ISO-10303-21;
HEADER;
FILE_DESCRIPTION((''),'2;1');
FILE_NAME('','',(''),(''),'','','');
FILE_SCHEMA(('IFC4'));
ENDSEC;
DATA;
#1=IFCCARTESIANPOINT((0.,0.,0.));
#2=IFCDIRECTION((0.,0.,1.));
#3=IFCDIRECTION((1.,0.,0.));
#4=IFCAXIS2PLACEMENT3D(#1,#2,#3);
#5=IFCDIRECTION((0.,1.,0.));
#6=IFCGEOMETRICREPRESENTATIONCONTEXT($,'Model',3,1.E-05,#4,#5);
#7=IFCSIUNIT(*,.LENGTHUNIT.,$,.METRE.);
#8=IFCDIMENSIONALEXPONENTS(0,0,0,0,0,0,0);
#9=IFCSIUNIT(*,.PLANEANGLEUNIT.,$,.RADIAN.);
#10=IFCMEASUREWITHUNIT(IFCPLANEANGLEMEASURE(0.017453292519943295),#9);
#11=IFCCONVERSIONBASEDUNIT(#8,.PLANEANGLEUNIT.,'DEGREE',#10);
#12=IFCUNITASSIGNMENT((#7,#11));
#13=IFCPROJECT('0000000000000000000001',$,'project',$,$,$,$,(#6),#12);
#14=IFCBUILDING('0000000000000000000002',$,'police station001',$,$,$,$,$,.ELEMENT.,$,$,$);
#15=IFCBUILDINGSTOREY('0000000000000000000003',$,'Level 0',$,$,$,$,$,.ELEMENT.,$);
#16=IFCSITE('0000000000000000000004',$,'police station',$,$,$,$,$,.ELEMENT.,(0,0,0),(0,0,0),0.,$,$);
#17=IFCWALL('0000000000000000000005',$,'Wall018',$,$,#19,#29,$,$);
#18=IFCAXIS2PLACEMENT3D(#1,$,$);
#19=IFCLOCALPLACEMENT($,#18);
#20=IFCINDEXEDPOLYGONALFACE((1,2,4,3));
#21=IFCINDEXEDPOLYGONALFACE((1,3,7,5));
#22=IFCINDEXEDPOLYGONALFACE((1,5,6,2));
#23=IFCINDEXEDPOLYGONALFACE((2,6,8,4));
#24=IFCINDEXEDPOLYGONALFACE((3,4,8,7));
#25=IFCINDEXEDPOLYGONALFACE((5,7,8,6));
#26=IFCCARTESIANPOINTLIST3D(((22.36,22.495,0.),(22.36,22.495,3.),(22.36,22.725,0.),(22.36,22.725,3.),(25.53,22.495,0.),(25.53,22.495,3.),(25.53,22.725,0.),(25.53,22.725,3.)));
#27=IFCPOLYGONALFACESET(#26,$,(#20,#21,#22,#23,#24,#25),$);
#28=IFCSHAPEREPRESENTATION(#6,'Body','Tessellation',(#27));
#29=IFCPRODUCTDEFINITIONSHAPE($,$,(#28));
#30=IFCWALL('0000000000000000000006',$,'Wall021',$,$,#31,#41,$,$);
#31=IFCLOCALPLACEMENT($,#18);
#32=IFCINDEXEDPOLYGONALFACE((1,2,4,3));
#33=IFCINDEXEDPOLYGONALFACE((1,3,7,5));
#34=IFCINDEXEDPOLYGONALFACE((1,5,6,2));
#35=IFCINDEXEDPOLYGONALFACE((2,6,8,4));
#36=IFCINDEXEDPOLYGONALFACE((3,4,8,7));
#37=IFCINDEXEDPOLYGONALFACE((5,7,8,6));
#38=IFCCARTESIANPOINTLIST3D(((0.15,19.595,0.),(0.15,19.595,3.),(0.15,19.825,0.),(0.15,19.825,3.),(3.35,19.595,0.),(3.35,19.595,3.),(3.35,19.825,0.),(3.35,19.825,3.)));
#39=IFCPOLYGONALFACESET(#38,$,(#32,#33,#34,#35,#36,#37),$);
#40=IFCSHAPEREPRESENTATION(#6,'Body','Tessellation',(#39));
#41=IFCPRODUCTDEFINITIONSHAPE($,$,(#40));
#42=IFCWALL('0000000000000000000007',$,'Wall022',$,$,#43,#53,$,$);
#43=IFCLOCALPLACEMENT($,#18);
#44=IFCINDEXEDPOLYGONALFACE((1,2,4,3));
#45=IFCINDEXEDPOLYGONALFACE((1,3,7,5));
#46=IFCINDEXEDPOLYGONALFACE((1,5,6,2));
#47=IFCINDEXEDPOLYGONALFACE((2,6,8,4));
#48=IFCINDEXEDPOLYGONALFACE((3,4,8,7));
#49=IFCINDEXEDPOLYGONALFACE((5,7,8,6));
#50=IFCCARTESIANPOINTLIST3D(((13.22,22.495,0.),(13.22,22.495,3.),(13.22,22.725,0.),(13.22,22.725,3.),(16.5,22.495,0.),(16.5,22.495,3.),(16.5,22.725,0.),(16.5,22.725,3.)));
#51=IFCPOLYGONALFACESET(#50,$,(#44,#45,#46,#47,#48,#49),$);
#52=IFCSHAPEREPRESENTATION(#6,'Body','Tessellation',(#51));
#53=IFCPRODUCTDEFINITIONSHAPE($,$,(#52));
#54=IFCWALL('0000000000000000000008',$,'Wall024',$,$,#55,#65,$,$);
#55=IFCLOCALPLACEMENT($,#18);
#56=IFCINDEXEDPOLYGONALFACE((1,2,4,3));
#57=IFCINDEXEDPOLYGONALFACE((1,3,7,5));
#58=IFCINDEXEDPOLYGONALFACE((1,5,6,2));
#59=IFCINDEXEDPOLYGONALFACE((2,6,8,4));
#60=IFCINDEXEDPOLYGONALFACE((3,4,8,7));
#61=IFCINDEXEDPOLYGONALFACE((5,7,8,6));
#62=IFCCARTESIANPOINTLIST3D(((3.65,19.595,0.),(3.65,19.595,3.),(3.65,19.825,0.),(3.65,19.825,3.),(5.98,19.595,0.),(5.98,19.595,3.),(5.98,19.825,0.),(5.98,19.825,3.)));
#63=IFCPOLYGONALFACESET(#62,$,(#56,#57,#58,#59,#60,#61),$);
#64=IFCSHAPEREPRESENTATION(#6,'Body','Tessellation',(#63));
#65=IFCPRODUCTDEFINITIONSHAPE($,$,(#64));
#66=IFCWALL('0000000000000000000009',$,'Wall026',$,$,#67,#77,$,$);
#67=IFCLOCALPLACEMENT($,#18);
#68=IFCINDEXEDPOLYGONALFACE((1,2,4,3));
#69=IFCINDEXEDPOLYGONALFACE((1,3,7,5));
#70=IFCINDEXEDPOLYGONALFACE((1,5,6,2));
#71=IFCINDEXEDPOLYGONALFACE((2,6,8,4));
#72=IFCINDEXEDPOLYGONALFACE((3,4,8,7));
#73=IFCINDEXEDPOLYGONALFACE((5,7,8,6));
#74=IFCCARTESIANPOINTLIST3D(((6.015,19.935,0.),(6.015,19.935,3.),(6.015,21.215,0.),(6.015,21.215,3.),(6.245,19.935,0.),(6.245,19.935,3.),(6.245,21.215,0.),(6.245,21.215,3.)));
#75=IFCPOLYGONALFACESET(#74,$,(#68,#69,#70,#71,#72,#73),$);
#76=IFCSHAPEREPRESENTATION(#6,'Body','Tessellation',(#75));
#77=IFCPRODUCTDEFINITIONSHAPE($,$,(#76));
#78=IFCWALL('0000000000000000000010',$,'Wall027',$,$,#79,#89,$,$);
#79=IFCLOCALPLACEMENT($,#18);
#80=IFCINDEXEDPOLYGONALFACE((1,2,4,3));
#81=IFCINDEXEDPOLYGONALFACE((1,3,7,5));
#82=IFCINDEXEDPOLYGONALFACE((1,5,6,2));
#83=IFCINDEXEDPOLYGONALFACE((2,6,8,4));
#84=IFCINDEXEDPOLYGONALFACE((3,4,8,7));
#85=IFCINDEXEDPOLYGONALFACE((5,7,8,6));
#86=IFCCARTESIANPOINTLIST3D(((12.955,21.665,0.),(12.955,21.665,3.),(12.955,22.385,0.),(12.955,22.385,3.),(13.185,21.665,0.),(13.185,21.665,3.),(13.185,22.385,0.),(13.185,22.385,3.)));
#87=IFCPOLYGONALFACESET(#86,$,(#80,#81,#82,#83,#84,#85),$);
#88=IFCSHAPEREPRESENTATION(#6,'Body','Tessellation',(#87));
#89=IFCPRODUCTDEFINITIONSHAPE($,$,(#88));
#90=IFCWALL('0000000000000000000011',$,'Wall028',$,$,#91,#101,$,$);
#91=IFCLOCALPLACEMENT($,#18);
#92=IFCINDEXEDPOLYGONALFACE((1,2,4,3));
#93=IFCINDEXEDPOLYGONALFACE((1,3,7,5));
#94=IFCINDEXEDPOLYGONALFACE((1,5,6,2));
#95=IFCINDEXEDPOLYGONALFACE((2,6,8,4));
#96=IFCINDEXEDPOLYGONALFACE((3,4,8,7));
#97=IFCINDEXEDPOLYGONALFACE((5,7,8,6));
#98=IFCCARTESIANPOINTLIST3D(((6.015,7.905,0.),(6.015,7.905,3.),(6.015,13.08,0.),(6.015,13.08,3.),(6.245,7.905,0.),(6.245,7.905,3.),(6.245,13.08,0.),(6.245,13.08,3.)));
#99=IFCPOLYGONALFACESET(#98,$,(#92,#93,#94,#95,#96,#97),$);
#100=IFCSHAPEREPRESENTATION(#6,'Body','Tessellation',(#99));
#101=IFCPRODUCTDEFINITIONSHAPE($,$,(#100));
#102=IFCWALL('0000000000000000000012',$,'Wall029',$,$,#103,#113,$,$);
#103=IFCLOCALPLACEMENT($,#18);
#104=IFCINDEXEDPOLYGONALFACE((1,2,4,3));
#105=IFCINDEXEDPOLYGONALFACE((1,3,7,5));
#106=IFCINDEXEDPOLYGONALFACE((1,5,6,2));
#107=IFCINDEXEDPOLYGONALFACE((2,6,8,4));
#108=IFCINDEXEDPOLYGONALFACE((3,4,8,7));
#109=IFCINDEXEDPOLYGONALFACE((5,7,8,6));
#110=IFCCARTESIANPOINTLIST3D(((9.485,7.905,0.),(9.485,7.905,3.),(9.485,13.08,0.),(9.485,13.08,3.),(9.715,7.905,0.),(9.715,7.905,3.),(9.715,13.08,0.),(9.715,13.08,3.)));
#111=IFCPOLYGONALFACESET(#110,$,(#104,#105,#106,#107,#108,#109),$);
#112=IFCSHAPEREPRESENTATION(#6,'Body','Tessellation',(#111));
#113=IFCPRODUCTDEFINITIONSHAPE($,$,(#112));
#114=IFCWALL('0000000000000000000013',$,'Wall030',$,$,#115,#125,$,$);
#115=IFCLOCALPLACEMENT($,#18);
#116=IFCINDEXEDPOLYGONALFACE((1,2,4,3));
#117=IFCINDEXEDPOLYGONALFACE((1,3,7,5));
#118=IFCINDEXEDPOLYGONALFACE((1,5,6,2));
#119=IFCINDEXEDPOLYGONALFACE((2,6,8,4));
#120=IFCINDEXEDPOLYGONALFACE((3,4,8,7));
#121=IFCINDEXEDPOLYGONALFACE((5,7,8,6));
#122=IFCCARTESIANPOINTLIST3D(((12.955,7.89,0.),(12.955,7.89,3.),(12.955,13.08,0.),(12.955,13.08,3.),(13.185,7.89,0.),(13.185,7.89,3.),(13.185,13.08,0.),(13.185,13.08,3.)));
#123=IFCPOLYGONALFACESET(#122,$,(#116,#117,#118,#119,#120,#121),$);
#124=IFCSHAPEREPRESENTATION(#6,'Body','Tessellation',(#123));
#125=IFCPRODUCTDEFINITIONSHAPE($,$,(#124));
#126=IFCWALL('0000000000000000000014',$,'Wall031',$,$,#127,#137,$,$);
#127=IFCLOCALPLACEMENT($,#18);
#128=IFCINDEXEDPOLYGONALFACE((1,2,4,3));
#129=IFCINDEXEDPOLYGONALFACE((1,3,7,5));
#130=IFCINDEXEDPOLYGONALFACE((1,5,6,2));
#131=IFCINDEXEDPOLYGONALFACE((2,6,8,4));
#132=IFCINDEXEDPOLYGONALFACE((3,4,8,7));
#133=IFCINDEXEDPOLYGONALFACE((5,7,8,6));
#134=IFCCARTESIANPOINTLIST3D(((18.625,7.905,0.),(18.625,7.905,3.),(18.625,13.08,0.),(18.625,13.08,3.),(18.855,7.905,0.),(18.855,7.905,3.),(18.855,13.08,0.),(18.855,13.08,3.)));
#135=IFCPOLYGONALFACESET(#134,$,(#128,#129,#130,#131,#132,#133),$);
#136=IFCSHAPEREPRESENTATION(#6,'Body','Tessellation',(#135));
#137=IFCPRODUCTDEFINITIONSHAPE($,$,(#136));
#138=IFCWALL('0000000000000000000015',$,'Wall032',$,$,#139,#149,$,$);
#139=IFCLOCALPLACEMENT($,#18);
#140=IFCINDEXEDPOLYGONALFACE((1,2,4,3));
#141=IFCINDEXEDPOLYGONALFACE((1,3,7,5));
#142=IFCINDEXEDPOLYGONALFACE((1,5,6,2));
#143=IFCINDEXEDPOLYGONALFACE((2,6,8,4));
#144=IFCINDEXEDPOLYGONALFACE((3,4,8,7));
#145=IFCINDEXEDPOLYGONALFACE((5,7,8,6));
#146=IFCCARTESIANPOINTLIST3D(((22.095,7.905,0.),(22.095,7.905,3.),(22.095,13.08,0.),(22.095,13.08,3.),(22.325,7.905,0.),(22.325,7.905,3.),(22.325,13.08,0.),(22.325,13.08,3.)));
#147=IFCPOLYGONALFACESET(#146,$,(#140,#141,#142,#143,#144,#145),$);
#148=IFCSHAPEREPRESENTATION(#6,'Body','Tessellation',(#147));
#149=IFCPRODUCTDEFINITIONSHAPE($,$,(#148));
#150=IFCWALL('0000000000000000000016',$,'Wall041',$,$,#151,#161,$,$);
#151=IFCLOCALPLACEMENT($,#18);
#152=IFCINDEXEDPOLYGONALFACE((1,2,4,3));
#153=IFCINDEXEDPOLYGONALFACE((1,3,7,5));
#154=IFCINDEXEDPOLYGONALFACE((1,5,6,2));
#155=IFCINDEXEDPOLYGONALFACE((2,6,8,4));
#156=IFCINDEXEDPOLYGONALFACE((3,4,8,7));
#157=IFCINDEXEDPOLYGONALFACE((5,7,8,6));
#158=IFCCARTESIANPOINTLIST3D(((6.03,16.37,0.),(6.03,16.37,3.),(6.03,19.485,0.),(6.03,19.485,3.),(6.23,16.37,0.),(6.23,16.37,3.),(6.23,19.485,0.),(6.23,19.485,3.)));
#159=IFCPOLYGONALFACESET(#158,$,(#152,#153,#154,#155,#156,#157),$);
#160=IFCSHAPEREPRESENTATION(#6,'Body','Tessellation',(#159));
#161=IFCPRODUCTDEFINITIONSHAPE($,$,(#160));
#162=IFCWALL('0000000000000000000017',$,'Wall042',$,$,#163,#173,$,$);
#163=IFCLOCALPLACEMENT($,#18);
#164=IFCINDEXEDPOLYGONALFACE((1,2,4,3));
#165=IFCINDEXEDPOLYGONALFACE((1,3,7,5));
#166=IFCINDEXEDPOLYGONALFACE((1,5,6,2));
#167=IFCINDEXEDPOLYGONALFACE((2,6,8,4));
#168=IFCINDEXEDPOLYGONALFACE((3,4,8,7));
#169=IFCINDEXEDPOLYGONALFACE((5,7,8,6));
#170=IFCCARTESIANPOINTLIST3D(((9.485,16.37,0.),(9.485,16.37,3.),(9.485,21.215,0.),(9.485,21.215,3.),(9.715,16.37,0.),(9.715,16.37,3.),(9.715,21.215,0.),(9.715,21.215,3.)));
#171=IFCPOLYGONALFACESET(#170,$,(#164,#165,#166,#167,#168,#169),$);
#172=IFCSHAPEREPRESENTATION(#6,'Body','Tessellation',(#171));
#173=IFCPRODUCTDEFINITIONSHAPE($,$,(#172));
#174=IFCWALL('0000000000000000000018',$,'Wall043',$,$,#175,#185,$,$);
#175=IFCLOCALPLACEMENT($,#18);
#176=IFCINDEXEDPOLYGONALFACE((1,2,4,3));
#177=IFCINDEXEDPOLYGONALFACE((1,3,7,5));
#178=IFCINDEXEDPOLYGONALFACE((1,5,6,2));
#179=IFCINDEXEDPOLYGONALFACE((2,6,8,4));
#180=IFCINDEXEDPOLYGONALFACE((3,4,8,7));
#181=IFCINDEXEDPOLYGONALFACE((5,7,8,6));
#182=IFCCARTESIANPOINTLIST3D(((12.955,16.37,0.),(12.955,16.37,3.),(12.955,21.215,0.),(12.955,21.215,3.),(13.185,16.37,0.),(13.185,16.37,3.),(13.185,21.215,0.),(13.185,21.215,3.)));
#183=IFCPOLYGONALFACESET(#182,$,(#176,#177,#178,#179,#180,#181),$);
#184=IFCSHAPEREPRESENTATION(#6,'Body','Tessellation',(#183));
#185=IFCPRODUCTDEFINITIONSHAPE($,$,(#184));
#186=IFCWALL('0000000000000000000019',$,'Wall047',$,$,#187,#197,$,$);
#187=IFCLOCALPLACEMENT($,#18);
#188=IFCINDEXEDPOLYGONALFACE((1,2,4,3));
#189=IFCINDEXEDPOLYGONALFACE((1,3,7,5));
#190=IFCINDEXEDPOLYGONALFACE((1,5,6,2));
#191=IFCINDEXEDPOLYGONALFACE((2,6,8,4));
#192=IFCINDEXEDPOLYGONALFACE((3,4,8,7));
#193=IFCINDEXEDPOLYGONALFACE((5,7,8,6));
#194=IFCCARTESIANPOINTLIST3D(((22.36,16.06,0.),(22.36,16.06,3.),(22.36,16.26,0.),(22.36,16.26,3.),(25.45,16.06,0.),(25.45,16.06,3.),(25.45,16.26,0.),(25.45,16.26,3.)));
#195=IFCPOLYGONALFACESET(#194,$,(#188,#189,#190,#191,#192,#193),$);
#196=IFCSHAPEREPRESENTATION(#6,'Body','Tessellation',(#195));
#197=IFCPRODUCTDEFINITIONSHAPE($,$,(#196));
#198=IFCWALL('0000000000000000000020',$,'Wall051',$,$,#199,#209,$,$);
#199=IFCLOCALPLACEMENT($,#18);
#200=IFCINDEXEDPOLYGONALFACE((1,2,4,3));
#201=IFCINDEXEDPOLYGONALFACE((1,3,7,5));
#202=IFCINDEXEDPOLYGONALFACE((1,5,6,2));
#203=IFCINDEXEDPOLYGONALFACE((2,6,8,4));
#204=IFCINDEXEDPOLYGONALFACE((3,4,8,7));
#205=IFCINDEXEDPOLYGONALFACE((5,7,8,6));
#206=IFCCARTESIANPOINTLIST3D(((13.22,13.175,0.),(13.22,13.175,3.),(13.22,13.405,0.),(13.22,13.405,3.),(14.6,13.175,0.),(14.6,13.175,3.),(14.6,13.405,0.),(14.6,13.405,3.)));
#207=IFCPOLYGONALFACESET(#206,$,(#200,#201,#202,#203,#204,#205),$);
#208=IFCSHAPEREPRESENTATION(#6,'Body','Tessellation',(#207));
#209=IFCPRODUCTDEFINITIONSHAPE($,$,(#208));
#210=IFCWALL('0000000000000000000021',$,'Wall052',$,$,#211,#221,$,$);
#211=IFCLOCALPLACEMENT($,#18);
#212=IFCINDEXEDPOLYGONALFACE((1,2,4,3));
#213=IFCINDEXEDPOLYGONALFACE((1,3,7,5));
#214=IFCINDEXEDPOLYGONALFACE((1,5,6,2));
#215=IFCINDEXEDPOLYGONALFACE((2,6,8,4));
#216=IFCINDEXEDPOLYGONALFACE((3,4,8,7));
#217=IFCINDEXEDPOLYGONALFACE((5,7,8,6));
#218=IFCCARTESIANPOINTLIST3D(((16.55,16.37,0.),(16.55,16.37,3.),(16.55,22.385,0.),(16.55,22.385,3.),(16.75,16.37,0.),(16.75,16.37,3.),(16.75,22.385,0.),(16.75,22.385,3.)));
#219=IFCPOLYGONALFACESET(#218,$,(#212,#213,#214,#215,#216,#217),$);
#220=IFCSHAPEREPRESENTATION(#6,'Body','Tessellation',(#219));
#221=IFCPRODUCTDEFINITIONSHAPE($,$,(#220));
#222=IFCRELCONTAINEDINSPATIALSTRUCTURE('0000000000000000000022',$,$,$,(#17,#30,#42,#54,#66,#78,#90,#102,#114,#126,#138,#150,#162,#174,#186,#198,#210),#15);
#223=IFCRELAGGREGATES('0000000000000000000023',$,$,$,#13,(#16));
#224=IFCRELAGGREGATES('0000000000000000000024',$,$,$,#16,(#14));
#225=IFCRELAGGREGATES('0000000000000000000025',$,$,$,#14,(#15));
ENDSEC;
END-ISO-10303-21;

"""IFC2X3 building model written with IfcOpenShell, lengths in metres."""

from ifc_helpers import new_model, entity, si_unit, converted_unit, direction, frame, frame_2d, origin_with_axes, place, context, project, spatial, rectangle, extrude, element, save


model = new_model("IFC2X3")

# Units and contexts
model_context = context("Model", 3, precision=1e-05, world=origin_with_axes(), true_north=direction((0.0, 1.0, 0.0)))
ifc_project = project(units=[si_unit("LENGTHUNIT", "METRE"), converted_unit("PLANEANGLEUNIT", "DEGREE", entity("IfcPlaneAngleMeasure", 0.017453292519943295), si_unit("PLANEANGLEUNIT", "RADIAN"), dimensions=[0, 0, 0, 0, 0, 0, 0])], contexts=[model_context])

# Site, building, storey
site = spatial("IfcSite", under=ifc_project, Name="police station", CompositionType="ELEMENT", RefLatitude=(0, 0, 0), RefLongitude=(0, 0, 0), RefElevation=0.0)
building = spatial("IfcBuilding", under=site, Name="police station001", CompositionType="ELEMENT")
storey = spatial("IfcBuildingStorey", under=building, Name="Level 0", CompositionType="ELEMENT")

# Shared definitions
placement = place(None, origin_with_axes())

# Walls
element("IfcWall", 1, at=placement, inside=storey, Name="Wall018", context=model_context, shape_type="SweptSolid", body=[
    extrude(rectangle(XDim=3.17, YDim=0.23, at=frame_2d((0.0, 0.0), x_axis=(-1.0, 0.0, 0.0))), frame((23.945, 22.61, 0.0), z_axis=(0.0, 0.0, 1.0), x_axis=(1.0, 0.0, 0.0)), (0.0, 0.0, 1.0), 3.0),
])
element("IfcWall", 2, at=placement, inside=storey, Name="Wall021", context=model_context, shape_type="SweptSolid", body=[
    extrude(rectangle(XDim=3.2, YDim=0.23, at=frame_2d((0.0, 0.0), x_axis=(1.0, 0.0, 0.0))), frame((1.75, 19.71, 0.0), z_axis=(0.0, 0.0, 1.0), x_axis=(1.0, 0.0, 0.0)), (0.0, 0.0, 1.0), 3.0),
])
element("IfcWall", 3, at=placement, inside=storey, Name="Wall022", context=model_context, shape_type="SweptSolid", body=[
    extrude(rectangle(XDim=3.28, YDim=0.23, at=frame_2d((0.0, 0.0), x_axis=(-1.0, 0.0, 0.0))), frame((14.86, 22.61, 0.0), z_axis=(0.0, 0.0, 1.0), x_axis=(1.0, 0.0, 0.0)), (0.0, 0.0, 1.0), 3.0),
])
element("IfcWall", 4, at=placement, inside=storey, Name="Wall024", context=model_context, shape_type="SweptSolid", body=[
    extrude(rectangle(XDim=2.33, YDim=0.23, at=frame_2d((0.0, 0.0), x_axis=(1.0, 0.0, 0.0))), frame((4.815, 19.71, 0.0), z_axis=(0.0, 0.0, 1.0), x_axis=(1.0, 0.0, 0.0)), (0.0, 0.0, 1.0), 3.0),
])
element("IfcWall", 5, at=placement, inside=storey, Name="Wall026", context=model_context, shape_type="SweptSolid", body=[
    extrude(rectangle(XDim=1.28, YDim=0.23, at=frame_2d((0.0, 0.0), x_axis=(0.0, -1.0, 0.0))), frame((6.13, 20.575, 0.0), z_axis=(0.0, 0.0, 1.0), x_axis=(1.0, 0.0, 0.0)), (0.0, 0.0, 1.0), 3.0),
])
element("IfcWall", 6, at=placement, inside=storey, Name="Wall027", context=model_context, shape_type="SweptSolid", body=[
    extrude(rectangle(XDim=0.72, YDim=0.23, at=frame_2d((0.0, 0.0), x_axis=(0.0, 1.0, 0.0))), frame((13.07, 22.025, 0.0), z_axis=(0.0, 0.0, 1.0), x_axis=(1.0, 0.0, 0.0)), (0.0, 0.0, 1.0), 3.0),
])
element("IfcWall", 7, at=placement, inside=storey, Name="Wall028", context=model_context, shape_type="SweptSolid", body=[
    extrude(rectangle(XDim=5.175, YDim=0.23, at=frame_2d((0.0, 0.0), x_axis=(0.0, -1.0, 0.0))), frame((6.13, 10.4925, 0.0), z_axis=(0.0, 0.0, 1.0), x_axis=(1.0, 0.0, 0.0)), (0.0, 0.0, 1.0), 3.0),
])
element("IfcWall", 8, at=placement, inside=storey, Name="Wall029", context=model_context, shape_type="SweptSolid", body=[
    extrude(rectangle(XDim=5.175, YDim=0.23, at=frame_2d((0.0, 0.0), x_axis=(0.0, -1.0, 0.0))), frame((9.6, 10.4925, 0.0), z_axis=(0.0, 0.0, 1.0), x_axis=(1.0, 0.0, 0.0)), (0.0, 0.0, 1.0), 3.0),
])
element("IfcWall", 9, at=placement, inside=storey, Name="Wall030", context=model_context, shape_type="SweptSolid", body=[
    extrude(rectangle(XDim=5.19, YDim=0.23, at=frame_2d((0.0, 0.0), x_axis=(0.0, 1.0, 0.0))), frame((13.07, 10.485, 0.0), z_axis=(0.0, 0.0, 1.0), x_axis=(1.0, 0.0, 0.0)), (0.0, 0.0, 1.0), 3.0),
])
element("IfcWall", 10, at=placement, inside=storey, Name="Wall031", context=model_context, shape_type="SweptSolid", body=[
    extrude(rectangle(XDim=5.175, YDim=0.23, at=frame_2d((0.0, 0.0), x_axis=(0.0, 1.0, 0.0))), frame((18.74, 10.4925, 0.0), z_axis=(0.0, 0.0, 1.0), x_axis=(1.0, 0.0, 0.0)), (0.0, 0.0, 1.0), 3.0),
])
element("IfcWall", 11, at=placement, inside=storey, Name="Wall032", context=model_context, shape_type="SweptSolid", body=[
    extrude(rectangle(XDim=5.175, YDim=0.23, at=frame_2d((0.0, 0.0), x_axis=(0.0, -1.0, 0.0))), frame((22.21, 10.4925, 0.0), z_axis=(0.0, 0.0, 1.0), x_axis=(1.0, 0.0, 0.0)), (0.0, 0.0, 1.0), 3.0),
])
element("IfcWall", 12, at=placement, inside=storey, Name="Wall041", context=model_context, shape_type="SweptSolid", body=[
    extrude(rectangle(XDim=3.115, YDim=0.2, at=frame_2d((0.0, 0.0), x_axis=(0.0, -1.0, 0.0))), frame((6.13, 17.9275, 0.0), z_axis=(0.0, 0.0, 1.0), x_axis=(1.0, 0.0, 0.0)), (0.0, 0.0, 1.0), 3.0),
])
element("IfcWall", 13, at=placement, inside=storey, Name="Wall042", context=model_context, shape_type="SweptSolid", body=[
    extrude(rectangle(XDim=4.845, YDim=0.23, at=frame_2d((0.0, 0.0), x_axis=(0.0, -1.0, 0.0))), frame((9.6, 18.7925, 0.0), z_axis=(0.0, 0.0, 1.0), x_axis=(1.0, 0.0, 0.0)), (0.0, 0.0, 1.0), 3.0),
])
element("IfcWall", 14, at=placement, inside=storey, Name="Wall043", context=model_context, shape_type="SweptSolid", body=[
    extrude(rectangle(XDim=4.845, YDim=0.23, at=frame_2d((0.0, 0.0), x_axis=(0.0, -1.0, 0.0))), frame((13.07, 18.7925, 0.0), z_axis=(0.0, 0.0, 1.0), x_axis=(1.0, 0.0, 0.0)), (0.0, 0.0, 1.0), 3.0),
])
element("IfcWall", 15, at=placement, inside=storey, Name="Wall047", context=model_context, shape_type="SweptSolid", body=[
    extrude(rectangle(XDim=3.09, YDim=0.2, at=frame_2d((0.0, 0.0), x_axis=(1.0, 0.0, 0.0))), frame((23.905, 16.16, 0.0), z_axis=(0.0, 0.0, 1.0), x_axis=(1.0, 0.0, 0.0)), (0.0, 0.0, 1.0), 3.0),
])
element("IfcWall", 16, at=placement, inside=storey, Name="Wall051", context=model_context, shape_type="SweptSolid", body=[
    extrude(rectangle(XDim=1.38, YDim=0.23, at=frame_2d((0.0, 0.0), x_axis=(1.0, 0.0, 0.0))), frame((13.91, 13.29, 0.0), z_axis=(0.0, 0.0, 1.0), x_axis=(1.0, 0.0, 0.0)), (0.0, 0.0, 1.0), 3.0),
])
element("IfcWall", 17, at=placement, inside=storey, Name="Wall052", context=model_context, shape_type="SweptSolid", body=[
    extrude(rectangle(XDim=6.015, YDim=0.2, at=frame_2d((0.0, 0.0), x_axis=(0.0, -1.0, 0.0))), frame((16.65, 19.3775, 0.0), z_axis=(0.0, 0.0, 1.0), x_axis=(1.0, 0.0, 0.0)), (0.0, 0.0, 1.0), 3.0),
])

save(model, "model.ifc")
